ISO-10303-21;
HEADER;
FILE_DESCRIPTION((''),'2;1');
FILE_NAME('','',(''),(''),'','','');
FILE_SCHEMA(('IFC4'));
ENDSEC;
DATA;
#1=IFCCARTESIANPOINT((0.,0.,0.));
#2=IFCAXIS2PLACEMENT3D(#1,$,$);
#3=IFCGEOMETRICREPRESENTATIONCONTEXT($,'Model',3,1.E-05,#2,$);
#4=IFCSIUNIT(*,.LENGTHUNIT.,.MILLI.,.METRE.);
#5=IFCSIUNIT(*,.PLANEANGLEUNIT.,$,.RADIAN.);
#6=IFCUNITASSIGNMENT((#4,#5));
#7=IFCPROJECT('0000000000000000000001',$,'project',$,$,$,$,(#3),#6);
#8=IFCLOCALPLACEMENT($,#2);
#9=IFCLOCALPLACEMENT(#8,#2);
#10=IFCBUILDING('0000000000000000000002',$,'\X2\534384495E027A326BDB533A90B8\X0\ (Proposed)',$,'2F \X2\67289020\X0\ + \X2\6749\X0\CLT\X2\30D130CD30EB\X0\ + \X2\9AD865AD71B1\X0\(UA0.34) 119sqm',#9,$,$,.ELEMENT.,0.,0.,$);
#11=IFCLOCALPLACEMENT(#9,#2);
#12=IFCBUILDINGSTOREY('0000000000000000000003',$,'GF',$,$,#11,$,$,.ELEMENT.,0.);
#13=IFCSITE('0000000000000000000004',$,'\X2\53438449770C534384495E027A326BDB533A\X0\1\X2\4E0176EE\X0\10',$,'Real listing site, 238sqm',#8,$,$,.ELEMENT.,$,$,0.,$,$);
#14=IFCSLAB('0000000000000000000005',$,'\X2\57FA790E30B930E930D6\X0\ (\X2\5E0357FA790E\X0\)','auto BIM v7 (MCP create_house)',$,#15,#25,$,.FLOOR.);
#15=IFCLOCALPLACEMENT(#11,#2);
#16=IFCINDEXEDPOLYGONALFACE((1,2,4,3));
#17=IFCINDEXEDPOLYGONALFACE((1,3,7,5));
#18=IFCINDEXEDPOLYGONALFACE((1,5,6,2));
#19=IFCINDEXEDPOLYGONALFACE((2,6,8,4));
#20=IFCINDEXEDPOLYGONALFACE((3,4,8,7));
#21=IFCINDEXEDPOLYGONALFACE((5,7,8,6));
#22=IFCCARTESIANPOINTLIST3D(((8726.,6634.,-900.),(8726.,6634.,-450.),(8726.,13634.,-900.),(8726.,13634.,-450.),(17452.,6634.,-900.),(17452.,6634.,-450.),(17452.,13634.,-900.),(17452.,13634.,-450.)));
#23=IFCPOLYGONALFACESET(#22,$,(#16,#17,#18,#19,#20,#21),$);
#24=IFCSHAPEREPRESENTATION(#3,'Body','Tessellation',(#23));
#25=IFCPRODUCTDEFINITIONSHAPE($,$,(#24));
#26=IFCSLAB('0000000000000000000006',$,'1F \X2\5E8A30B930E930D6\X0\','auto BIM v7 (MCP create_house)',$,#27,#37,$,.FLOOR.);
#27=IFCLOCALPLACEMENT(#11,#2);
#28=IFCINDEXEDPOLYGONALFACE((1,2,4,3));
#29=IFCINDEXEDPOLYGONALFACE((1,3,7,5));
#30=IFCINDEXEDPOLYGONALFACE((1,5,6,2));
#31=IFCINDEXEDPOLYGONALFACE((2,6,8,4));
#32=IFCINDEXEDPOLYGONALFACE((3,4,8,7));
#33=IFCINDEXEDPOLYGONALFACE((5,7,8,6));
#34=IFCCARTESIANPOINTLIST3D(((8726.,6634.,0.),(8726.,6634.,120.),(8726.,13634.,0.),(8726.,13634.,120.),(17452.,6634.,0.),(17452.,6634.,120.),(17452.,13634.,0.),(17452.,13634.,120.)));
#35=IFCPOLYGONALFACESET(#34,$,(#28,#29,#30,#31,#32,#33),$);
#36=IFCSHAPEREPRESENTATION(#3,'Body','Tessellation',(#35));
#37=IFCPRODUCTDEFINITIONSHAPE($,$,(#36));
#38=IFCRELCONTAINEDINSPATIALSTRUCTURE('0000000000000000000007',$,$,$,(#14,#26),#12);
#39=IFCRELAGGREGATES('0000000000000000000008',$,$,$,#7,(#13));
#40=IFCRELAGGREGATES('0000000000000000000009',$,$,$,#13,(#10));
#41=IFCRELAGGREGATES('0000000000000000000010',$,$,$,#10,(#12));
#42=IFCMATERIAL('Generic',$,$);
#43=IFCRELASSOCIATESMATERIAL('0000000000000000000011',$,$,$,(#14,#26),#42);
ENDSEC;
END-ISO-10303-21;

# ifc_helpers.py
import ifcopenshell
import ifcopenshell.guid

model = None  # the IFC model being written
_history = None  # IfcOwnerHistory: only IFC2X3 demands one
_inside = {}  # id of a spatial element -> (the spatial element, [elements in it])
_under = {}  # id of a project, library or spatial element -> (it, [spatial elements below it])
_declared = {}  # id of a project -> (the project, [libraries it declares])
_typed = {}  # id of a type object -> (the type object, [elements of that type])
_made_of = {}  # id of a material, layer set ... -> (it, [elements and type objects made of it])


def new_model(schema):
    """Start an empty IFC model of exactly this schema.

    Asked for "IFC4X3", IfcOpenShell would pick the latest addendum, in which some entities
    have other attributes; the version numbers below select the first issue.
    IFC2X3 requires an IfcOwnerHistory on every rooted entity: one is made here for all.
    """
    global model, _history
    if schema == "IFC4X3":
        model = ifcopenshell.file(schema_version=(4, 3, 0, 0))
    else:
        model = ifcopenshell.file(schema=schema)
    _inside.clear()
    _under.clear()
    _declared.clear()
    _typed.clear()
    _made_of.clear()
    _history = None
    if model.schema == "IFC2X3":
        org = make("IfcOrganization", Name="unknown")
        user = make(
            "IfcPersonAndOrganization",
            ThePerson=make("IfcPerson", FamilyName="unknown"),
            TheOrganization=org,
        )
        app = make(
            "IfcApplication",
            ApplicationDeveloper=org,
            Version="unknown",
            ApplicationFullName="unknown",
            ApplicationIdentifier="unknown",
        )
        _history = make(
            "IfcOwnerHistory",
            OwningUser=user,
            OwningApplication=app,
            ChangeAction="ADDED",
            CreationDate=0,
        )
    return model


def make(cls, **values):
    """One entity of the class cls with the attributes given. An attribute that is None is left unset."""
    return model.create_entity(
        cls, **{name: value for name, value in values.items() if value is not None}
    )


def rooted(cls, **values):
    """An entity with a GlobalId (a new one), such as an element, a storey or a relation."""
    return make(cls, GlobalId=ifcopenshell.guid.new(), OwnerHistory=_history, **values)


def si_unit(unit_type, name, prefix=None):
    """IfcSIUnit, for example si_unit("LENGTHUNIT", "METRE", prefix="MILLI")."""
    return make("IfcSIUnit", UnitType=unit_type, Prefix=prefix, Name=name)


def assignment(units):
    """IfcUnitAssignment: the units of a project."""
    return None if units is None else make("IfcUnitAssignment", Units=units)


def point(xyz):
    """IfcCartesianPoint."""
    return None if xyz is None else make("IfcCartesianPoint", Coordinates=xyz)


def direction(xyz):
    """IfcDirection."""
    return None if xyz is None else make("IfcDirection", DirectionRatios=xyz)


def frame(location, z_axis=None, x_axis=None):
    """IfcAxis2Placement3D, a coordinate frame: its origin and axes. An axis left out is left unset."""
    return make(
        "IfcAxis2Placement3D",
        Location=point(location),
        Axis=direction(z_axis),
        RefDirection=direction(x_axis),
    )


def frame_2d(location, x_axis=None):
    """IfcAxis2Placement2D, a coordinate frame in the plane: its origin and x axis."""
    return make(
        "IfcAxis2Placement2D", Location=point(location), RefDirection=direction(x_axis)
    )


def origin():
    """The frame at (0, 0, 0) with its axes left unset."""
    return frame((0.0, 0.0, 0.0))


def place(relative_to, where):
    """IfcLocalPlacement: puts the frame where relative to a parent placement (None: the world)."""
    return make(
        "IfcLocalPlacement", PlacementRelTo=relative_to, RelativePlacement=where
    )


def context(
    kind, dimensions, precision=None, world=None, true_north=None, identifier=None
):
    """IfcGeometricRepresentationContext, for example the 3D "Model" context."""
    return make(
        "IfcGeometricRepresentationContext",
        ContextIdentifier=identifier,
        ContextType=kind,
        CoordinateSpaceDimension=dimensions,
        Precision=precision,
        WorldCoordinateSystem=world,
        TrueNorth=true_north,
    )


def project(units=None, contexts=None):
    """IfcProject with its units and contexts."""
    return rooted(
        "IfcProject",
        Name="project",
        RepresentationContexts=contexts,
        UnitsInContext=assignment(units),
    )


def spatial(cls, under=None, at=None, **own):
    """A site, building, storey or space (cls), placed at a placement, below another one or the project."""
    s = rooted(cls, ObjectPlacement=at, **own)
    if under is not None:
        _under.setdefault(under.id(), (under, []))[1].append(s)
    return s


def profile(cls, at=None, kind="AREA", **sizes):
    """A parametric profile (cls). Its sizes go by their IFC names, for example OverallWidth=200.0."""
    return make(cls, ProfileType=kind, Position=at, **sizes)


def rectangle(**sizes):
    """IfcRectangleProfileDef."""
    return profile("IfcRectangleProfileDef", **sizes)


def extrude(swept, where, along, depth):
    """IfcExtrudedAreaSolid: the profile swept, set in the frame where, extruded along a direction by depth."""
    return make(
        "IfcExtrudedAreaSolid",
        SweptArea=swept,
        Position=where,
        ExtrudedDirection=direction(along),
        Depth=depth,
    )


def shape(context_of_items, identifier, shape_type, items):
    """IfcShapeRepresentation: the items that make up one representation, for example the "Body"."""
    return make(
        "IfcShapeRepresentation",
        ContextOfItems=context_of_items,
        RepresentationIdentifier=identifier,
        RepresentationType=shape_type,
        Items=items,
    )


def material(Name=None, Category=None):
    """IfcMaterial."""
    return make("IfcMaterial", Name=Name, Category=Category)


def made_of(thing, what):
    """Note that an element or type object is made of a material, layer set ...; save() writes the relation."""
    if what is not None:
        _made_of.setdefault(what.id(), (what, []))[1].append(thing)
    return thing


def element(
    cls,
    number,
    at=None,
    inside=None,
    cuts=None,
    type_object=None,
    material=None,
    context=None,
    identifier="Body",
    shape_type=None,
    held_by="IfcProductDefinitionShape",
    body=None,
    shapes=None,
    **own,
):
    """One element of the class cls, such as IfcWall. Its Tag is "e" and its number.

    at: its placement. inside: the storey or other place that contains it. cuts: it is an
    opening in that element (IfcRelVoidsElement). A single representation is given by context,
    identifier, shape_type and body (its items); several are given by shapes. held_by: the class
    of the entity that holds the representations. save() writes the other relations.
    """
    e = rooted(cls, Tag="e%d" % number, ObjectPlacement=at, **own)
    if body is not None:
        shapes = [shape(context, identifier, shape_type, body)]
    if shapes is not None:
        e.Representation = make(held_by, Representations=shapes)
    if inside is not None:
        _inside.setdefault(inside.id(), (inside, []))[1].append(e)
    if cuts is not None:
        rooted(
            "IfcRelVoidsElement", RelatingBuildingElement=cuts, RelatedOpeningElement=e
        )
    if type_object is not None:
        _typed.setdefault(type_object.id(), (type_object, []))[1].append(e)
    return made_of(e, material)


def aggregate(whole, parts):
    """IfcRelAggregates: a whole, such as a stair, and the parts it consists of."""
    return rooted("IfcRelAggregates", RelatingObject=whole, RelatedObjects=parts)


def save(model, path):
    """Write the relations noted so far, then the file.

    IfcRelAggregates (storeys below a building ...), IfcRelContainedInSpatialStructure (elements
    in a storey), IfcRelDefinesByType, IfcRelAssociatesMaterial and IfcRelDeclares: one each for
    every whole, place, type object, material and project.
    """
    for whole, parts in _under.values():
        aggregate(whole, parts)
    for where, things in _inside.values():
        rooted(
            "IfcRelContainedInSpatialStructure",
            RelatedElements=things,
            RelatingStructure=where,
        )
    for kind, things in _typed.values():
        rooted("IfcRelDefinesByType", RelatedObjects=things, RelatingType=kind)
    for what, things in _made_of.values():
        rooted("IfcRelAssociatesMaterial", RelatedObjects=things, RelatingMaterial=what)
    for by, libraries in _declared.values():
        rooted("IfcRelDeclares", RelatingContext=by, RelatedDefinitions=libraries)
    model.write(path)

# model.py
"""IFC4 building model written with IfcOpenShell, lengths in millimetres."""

from ifc_helpers import new_model, si_unit, frame, frame_2d, origin, place, context, project, spatial, rectangle, extrude, material, element, save


model = new_model("IFC4")

# Units and contexts
model_context = context("Model", 3, precision=1e-05, world=origin())
ifc_project = project(units=[si_unit("LENGTHUNIT", "METRE", prefix="MILLI"), si_unit("PLANEANGLEUNIT", "RADIAN")], contexts=[model_context])

# Site, building, storey
site_placement = place(None, origin())
site = spatial("IfcSite", under=ifc_project, at=site_placement, Name="千葉県千葉市稲毛区1丁目10", ObjectType="Real listing site, 238sqm", CompositionType="ELEMENT", RefElevation=0.0)
building_placement = place(site_placement, origin())
building = spatial("IfcBuilding", under=site, at=building_placement, Name="千葉市稲毛区邸 (Proposed)", ObjectType="2F 木造 + 杉CLTパネル + 高断熱(UA0.34) 119sqm", CompositionType="ELEMENT", ElevationOfRefHeight=0.0, ElevationOfTerrain=0.0)
storey_placement = place(building_placement, origin())
storey = spatial("IfcBuildingStorey", under=building, at=storey_placement, Name="GF", CompositionType="ELEMENT", Elevation=0.0)

# Slabs
ifc_material = material(Name="Generic")
slab_1_placement = place(storey_placement, frame((4363.0, 3317.0, -450.0)))
element("IfcSlab", 1, at=slab_1_placement, inside=storey, material=ifc_material, Name="基礎スラブ (布基礎)", Description="auto BIM v7 (MCP create_house)", PredefinedType="FLOOR", context=model_context, shape_type="SweptSolid", body=[
    extrude(rectangle(XDim=8726.0, YDim=7000.0, at=frame_2d((4363.0, 3500.0))), frame((4363.0, 3317.0, -450.0)), (0.0, 0.0, 1.0), 450.0),
])
slab_2_placement = place(storey_placement, frame((4363.0, 3317.0, 0.0)))
element("IfcSlab", 2, at=slab_2_placement, inside=storey, material=ifc_material, Name="1F 床スラブ", Description="auto BIM v7 (MCP create_house)", PredefinedType="FLOOR", context=model_context, shape_type="SweptSolid", body=[
    extrude(rectangle(XDim=8726.0, YDim=7000.0, at=frame_2d((4363.0, 3500.0))), frame((4363.0, 3317.0, 0.0)), (0.0, 0.0, 1.0), 120.0),
])

save(model, "model.ifc")
